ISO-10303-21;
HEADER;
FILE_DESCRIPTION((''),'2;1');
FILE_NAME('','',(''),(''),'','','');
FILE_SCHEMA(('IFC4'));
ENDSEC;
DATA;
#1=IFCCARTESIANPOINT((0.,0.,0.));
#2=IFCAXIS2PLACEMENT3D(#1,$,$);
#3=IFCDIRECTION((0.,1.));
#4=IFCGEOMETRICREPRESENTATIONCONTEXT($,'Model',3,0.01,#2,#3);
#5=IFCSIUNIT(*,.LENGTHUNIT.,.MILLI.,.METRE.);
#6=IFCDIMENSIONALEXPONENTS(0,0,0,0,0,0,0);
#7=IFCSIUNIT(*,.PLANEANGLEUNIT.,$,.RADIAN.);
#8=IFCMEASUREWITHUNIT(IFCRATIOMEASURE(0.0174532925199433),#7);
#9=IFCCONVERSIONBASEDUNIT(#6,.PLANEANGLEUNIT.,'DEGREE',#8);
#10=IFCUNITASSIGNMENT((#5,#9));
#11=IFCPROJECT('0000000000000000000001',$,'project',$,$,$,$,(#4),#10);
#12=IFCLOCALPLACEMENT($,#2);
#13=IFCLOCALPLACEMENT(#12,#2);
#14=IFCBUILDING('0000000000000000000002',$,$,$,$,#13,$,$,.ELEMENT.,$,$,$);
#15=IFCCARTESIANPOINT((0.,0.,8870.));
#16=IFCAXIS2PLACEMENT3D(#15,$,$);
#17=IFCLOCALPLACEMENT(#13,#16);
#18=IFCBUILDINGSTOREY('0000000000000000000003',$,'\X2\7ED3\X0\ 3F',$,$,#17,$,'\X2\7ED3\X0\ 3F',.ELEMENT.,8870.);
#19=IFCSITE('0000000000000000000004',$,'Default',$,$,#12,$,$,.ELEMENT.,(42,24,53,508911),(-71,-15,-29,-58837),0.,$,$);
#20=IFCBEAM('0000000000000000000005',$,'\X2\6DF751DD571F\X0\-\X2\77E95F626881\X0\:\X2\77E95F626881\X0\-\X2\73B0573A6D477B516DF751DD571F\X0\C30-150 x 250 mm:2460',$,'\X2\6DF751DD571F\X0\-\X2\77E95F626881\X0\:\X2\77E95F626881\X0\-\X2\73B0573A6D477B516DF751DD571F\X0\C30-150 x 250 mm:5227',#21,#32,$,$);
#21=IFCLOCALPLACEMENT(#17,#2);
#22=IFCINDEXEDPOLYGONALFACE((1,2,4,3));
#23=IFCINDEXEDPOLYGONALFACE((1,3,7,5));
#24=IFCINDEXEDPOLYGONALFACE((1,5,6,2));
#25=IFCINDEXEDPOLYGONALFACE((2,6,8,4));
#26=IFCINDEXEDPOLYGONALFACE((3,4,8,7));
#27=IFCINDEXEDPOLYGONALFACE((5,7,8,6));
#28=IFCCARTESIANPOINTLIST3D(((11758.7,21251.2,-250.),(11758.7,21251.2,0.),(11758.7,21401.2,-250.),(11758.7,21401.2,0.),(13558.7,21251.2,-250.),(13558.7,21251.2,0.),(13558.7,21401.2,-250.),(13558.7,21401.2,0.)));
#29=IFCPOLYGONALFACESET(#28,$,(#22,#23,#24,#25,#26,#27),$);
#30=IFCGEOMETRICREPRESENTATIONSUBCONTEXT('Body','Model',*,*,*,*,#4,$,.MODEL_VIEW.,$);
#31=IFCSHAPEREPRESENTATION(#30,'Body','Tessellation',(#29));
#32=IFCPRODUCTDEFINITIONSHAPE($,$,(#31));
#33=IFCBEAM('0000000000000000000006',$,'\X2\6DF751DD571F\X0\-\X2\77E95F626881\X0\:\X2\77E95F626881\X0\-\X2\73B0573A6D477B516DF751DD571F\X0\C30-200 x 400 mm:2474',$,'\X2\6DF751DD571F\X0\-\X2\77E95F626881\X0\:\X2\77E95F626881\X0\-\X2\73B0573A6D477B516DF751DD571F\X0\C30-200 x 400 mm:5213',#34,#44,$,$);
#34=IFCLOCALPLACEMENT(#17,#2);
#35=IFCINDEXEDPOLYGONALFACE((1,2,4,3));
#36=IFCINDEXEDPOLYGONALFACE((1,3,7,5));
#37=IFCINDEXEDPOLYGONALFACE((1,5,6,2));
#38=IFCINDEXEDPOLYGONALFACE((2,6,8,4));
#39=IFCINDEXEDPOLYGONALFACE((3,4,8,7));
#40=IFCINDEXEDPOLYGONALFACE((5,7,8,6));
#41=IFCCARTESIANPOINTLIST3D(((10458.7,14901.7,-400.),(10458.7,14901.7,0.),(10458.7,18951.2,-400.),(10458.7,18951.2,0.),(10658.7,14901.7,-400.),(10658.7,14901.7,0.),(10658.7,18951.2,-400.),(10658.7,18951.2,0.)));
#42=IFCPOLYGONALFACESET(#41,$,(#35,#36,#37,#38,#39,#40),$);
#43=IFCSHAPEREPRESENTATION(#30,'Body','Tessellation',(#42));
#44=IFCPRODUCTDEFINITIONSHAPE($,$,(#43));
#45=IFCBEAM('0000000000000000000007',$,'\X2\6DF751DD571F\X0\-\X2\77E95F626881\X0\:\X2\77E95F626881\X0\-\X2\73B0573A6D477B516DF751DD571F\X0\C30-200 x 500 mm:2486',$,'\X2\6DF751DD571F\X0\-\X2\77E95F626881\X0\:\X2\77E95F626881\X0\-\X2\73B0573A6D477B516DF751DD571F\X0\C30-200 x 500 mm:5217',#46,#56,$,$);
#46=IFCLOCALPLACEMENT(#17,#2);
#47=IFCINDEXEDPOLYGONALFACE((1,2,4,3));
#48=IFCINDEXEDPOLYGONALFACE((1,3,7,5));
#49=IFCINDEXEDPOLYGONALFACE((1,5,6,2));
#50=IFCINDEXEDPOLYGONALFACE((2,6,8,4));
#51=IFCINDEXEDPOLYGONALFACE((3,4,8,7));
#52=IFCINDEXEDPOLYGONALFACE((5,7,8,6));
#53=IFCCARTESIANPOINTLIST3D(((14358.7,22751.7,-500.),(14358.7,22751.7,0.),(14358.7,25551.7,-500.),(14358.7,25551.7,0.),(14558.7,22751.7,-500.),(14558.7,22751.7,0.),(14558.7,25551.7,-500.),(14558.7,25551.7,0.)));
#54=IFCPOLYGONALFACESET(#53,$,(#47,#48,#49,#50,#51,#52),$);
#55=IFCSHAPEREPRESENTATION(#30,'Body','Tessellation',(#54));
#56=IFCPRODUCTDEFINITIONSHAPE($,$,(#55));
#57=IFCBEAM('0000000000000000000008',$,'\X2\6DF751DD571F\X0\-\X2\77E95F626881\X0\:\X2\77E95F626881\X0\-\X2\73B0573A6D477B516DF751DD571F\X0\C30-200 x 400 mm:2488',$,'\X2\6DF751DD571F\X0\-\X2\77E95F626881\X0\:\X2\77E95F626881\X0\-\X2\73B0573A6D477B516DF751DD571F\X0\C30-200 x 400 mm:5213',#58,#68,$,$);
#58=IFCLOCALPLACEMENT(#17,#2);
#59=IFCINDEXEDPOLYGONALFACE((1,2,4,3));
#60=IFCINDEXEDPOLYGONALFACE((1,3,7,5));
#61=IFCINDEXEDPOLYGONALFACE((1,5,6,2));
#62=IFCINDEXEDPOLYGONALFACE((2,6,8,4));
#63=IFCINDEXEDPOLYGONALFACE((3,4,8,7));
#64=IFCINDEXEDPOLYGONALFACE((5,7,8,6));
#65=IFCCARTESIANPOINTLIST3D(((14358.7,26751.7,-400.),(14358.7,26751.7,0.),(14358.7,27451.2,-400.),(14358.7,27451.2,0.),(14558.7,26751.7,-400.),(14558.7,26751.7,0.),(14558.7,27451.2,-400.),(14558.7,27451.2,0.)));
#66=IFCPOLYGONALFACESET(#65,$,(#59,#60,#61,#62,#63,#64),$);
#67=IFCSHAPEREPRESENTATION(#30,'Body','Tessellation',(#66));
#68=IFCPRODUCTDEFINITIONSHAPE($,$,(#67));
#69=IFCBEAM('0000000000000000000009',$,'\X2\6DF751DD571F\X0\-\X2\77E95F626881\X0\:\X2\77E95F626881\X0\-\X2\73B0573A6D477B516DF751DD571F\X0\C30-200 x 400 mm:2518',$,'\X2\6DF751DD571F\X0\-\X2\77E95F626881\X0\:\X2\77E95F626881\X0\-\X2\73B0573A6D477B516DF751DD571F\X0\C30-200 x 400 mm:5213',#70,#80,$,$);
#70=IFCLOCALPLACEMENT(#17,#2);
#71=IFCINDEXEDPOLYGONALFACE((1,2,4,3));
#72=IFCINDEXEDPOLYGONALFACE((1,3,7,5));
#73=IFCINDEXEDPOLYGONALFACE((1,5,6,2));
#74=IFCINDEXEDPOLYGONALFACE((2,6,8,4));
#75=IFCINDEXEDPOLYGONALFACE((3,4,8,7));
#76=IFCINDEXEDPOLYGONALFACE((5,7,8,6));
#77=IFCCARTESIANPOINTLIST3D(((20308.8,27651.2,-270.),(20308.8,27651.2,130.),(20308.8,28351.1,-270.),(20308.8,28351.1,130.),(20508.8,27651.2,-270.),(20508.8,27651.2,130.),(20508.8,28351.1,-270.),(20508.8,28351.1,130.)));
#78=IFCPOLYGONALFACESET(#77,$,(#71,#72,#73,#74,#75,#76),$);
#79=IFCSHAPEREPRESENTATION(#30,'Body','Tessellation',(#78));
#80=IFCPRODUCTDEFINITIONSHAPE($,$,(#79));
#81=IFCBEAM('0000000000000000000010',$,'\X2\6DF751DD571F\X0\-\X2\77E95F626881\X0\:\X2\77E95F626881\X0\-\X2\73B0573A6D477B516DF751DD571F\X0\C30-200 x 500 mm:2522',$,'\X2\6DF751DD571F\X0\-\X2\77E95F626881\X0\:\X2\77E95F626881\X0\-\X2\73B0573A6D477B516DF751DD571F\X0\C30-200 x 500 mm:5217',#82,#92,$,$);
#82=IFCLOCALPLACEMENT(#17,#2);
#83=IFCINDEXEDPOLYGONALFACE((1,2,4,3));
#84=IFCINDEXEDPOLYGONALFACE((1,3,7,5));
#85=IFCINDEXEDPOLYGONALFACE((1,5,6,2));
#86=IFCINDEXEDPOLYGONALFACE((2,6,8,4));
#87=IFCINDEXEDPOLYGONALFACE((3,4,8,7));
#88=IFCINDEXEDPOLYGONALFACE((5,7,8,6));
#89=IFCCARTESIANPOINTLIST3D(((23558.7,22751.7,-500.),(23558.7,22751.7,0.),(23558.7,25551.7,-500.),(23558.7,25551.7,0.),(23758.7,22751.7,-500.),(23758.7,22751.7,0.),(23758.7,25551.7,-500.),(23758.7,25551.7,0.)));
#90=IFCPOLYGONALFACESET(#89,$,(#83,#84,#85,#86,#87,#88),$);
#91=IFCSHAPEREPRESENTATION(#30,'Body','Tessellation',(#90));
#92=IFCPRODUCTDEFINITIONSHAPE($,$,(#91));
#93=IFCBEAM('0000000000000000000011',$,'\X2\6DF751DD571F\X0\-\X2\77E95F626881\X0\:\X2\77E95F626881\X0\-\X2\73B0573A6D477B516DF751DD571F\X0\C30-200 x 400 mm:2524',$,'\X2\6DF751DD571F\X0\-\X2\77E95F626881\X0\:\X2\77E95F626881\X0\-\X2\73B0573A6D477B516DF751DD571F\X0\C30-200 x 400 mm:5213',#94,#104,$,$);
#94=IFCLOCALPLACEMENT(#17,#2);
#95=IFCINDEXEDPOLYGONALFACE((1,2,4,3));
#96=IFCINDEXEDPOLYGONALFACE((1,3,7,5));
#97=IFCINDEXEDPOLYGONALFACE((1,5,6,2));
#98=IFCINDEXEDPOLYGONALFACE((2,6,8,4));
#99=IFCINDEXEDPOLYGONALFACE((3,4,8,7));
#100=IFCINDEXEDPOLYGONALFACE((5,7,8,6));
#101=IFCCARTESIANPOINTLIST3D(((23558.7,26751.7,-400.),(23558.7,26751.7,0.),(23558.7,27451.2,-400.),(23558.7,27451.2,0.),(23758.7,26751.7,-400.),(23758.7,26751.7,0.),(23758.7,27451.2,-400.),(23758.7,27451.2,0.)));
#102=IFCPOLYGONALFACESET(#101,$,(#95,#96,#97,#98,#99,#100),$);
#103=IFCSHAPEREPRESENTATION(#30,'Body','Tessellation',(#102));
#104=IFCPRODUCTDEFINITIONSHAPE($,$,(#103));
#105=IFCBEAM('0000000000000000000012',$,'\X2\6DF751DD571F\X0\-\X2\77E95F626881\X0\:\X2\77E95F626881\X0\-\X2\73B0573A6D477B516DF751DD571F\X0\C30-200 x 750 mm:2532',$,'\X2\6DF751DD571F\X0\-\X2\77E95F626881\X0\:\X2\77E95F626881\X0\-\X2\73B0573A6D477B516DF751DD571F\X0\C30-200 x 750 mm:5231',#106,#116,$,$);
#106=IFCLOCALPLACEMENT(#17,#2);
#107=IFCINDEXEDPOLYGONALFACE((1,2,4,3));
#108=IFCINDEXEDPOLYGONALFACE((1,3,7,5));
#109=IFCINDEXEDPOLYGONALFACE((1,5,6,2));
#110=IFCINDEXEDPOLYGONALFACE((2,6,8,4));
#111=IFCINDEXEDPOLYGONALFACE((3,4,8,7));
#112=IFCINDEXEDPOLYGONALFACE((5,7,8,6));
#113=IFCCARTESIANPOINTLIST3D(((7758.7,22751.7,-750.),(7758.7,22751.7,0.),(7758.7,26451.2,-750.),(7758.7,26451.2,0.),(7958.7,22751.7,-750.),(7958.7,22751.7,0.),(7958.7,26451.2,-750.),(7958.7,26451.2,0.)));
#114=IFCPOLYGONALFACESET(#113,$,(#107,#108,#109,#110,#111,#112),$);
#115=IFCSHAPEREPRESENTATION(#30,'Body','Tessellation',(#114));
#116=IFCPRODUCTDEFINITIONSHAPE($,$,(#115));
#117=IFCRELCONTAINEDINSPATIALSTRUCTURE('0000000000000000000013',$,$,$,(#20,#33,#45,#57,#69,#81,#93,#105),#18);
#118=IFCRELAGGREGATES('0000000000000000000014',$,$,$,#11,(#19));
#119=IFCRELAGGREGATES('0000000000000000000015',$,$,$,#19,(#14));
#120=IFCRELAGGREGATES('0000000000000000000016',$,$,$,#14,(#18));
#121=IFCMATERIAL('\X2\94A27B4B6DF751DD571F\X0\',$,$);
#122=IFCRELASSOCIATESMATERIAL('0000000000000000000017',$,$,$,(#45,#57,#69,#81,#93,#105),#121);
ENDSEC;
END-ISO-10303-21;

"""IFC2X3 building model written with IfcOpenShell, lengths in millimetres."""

from ifc_helpers import new_model, entity, si_unit, converted_unit, direction, frame, frame_2d, origin, origin_2d_with_axis, place, context, subcontext, project, spatial, rectangle, extrude, material, element, save


model = new_model("IFC2X3")

# Units and contexts
model_context = context("Model", 3, precision=0.01, world=origin(), true_north=direction((0.0, 1.0)))
body_context = subcontext(model_context, "Body", "Model", "MODEL_VIEW")
ifc_project = project(units=[si_unit("LENGTHUNIT", "METRE", prefix="MILLI"), converted_unit("PLANEANGLEUNIT", "DEGREE", entity("IfcRatioMeasure", 0.0174532925199433), si_unit("PLANEANGLEUNIT", "RADIAN"), dimensions=[0, 0, 0, 0, 0, 0, 0])], contexts=[model_context])

# Site, building, storey
site_placement = place(None, origin())
site = spatial("IfcSite", under=ifc_project, at=site_placement, Name="Default", CompositionType="ELEMENT", RefLatitude=(42, 24, 53, 508911), RefLongitude=(-71, -15, -29, -58837), RefElevation=0.0)
building_placement = place(site_placement, origin())
building = spatial("IfcBuilding", under=site, at=building_placement, CompositionType="ELEMENT")
storey_placement = place(building_placement, frame((0.0, 0.0, 8870.0)))
storey = spatial("IfcBuildingStorey", under=building, at=storey_placement, Name="结 3F", LongName="结 3F", CompositionType="ELEMENT", Elevation=8870.0)

# Beams
ifc_material = material(Name="钢筋混凝土")
beam_1_placement = place(storey_placement, frame((11683.7, 21326.2, 0.0)))
element("IfcBeam", 1, at=beam_1_placement, inside=storey, Name="混凝土-矩形梁:矩形梁-现场浇筑混凝土C30-150 x 250 mm:2460", ObjectType="混凝土-矩形梁:矩形梁-现场浇筑混凝土C30-150 x 250 mm:5227", context=body_context, shape_type="SweptSolid", body=[
    extrude(rectangle(XDim=250.0, YDim=150.0, at=frame_2d((0.0, 0.0), x_axis=(1.0, 0.0))), frame((75.0, 0.0, -125.0), z_axis=(1.0, 0.0, 0.0), x_axis=(0.0, 0.0, -1.0)), (0.0, 0.0, 1.0), 1800.0),
])
beam_2_placement = place(storey_placement, frame((10558.7, 14801.7, 0.0), z_axis=(0.0, 0.0, 1.0), x_axis=(0.0, 1.0, 0.0)))
element("IfcBeam", 2, at=beam_2_placement, inside=storey, Name="混凝土-矩形梁:矩形梁-现场浇筑混凝土C30-200 x 400 mm:2474", ObjectType="混凝土-矩形梁:矩形梁-现场浇筑混凝土C30-200 x 400 mm:5213", context=body_context, shape_type="SweptSolid", body=[
    extrude(rectangle(XDim=400.0, YDim=200.0, at=frame_2d((0.0, 0.0), x_axis=(1.0, 0.0))), frame((100.0, 0.0, -200.0), z_axis=(1.0, 0.0, 0.0), x_axis=(0.0, 0.0, -1.0)), (0.0, 0.0, 1.0), 4049.5),
])
beam_3_placement = place(storey_placement, frame((14458.7, 22651.7, 0.0), z_axis=(0.0, 0.0, 1.0), x_axis=(0.0, 1.0, 0.0)))
element("IfcBeam", 3, at=beam_3_placement, inside=storey, material=ifc_material, Name="混凝土-矩形梁:矩形梁-现场浇筑混凝土C30-200 x 500 mm:2486", ObjectType="混凝土-矩形梁:矩形梁-现场浇筑混凝土C30-200 x 500 mm:5217", context=body_context, shape_type="SweptSolid", body=[
    extrude(rectangle(XDim=500.0, YDim=200.0, at=frame_2d((0.0, 0.0), x_axis=(1.0, 0.0))), frame((100.0, 0.0, -250.0), z_axis=(1.0, 0.0, 0.0), x_axis=(0.0, 0.0, -1.0)), (0.0, 0.0, 1.0), 2800.0),
])
beam_4_placement = place(storey_placement, frame((14458.7, 26651.7, 0.0), z_axis=(0.0, 0.0, 1.0), x_axis=(0.0, 1.0, 0.0)))
element("IfcBeam", 4, at=beam_4_placement, inside=storey, material=ifc_material, Name="混凝土-矩形梁:矩形梁-现场浇筑混凝土C30-200 x 400 mm:2488", ObjectType="混凝土-矩形梁:矩形梁-现场浇筑混凝土C30-200 x 400 mm:5213", context=body_context, shape_type="SweptSolid", body=[
    extrude(rectangle(XDim=400.0, YDim=200.0, at=frame_2d((0.0, 0.0), x_axis=(1.0, 0.0))), frame((100.0, 0.0, -200.0), z_axis=(1.0, 0.0, 0.0), x_axis=(0.0, 0.0, -1.0)), (0.0, 0.0, 1.0), 699.5),
])
beam_5_placement = place(storey_placement, frame((20408.8, 27551.2, 130.0), z_axis=(0.0, 0.0, 1.0), x_axis=(0.0, 1.0, 0.0)))
element("IfcBeam", 5, at=beam_5_placement, inside=storey, material=ifc_material, Name="混凝土-矩形梁:矩形梁-现场浇筑混凝土C30-200 x 400 mm:2518", ObjectType="混凝土-矩形梁:矩形梁-现场浇筑混凝土C30-200 x 400 mm:5213", context=body_context, shape_type="SweptSolid", body=[
    extrude(rectangle(XDim=400.0, YDim=200.0, at=origin_2d_with_axis()), frame((100.0, 0.0, -200.0), z_axis=(1.0, 0.0, 0.0), x_axis=(0.0, 0.0, -1.0)), (0.0, 0.0, 1.0), 699.9),
])
beam_6_placement = place(storey_placement, frame((23658.7, 22651.7, 0.0), z_axis=(0.0, 0.0, 1.0), x_axis=(0.0, 1.0, 0.0)))
element("IfcBeam", 6, at=beam_6_placement, inside=storey, material=ifc_material, Name="混凝土-矩形梁:矩形梁-现场浇筑混凝土C30-200 x 500 mm:2522", ObjectType="混凝土-矩形梁:矩形梁-现场浇筑混凝土C30-200 x 500 mm:5217", context=body_context, shape_type="SweptSolid", body=[
    extrude(rectangle(XDim=500.0, YDim=200.0, at=frame_2d((0.0, 0.0), x_axis=(1.0, 0.0))), frame((100.0, 0.0, -250.0), z_axis=(1.0, 0.0, 0.0), x_axis=(0.0, 0.0, -1.0)), (0.0, 0.0, 1.0), 2800.0),
])
beam_7_placement = place(storey_placement, frame((23658.7, 26651.7, 0.0), z_axis=(0.0, 0.0, 1.0), x_axis=(0.0, 1.0, 0.0)))
element("IfcBeam", 7, at=beam_7_placement, inside=storey, material=ifc_material, Name="混凝土-矩形梁:矩形梁-现场浇筑混凝土C30-200 x 400 mm:2524", ObjectType="混凝土-矩形梁:矩形梁-现场浇筑混凝土C30-200 x 400 mm:5213", context=body_context, shape_type="SweptSolid", body=[
    extrude(rectangle(XDim=400.0, YDim=200.0, at=frame_2d((0.0, 0.0), x_axis=(1.0, 0.0))), frame((100.0, 0.0, -200.0), z_axis=(1.0, 0.0, 0.0), x_axis=(0.0, 0.0, -1.0)), (0.0, 0.0, 1.0), 699.5),
])
beam_8_placement = place(storey_placement, frame((7858.7, 22651.7, 0.0), z_axis=(0.0, 0.0, 1.0), x_axis=(0.0, 1.0, 0.0)))
element("IfcBeam", 8, at=beam_8_placement, inside=storey, material=ifc_material, Name="混凝土-矩形梁:矩形梁-现场浇筑混凝土C30-200 x 750 mm:2532", ObjectType="混凝土-矩形梁:矩形梁-现场浇筑混凝土C30-200 x 750 mm:5231", context=body_context, shape_type="SweptSolid", body=[
    extrude(rectangle(XDim=750.0, YDim=200.0, at=frame_2d((0.0, 0.0), x_axis=(1.0, 0.0))), frame((100.0, 0.0, -375.0), z_axis=(1.0, 0.0, 0.0), x_axis=(0.0, 0.0, -1.0)), (0.0, 0.0, 1.0), 3699.5),
])

save(model, "model.ifc")
